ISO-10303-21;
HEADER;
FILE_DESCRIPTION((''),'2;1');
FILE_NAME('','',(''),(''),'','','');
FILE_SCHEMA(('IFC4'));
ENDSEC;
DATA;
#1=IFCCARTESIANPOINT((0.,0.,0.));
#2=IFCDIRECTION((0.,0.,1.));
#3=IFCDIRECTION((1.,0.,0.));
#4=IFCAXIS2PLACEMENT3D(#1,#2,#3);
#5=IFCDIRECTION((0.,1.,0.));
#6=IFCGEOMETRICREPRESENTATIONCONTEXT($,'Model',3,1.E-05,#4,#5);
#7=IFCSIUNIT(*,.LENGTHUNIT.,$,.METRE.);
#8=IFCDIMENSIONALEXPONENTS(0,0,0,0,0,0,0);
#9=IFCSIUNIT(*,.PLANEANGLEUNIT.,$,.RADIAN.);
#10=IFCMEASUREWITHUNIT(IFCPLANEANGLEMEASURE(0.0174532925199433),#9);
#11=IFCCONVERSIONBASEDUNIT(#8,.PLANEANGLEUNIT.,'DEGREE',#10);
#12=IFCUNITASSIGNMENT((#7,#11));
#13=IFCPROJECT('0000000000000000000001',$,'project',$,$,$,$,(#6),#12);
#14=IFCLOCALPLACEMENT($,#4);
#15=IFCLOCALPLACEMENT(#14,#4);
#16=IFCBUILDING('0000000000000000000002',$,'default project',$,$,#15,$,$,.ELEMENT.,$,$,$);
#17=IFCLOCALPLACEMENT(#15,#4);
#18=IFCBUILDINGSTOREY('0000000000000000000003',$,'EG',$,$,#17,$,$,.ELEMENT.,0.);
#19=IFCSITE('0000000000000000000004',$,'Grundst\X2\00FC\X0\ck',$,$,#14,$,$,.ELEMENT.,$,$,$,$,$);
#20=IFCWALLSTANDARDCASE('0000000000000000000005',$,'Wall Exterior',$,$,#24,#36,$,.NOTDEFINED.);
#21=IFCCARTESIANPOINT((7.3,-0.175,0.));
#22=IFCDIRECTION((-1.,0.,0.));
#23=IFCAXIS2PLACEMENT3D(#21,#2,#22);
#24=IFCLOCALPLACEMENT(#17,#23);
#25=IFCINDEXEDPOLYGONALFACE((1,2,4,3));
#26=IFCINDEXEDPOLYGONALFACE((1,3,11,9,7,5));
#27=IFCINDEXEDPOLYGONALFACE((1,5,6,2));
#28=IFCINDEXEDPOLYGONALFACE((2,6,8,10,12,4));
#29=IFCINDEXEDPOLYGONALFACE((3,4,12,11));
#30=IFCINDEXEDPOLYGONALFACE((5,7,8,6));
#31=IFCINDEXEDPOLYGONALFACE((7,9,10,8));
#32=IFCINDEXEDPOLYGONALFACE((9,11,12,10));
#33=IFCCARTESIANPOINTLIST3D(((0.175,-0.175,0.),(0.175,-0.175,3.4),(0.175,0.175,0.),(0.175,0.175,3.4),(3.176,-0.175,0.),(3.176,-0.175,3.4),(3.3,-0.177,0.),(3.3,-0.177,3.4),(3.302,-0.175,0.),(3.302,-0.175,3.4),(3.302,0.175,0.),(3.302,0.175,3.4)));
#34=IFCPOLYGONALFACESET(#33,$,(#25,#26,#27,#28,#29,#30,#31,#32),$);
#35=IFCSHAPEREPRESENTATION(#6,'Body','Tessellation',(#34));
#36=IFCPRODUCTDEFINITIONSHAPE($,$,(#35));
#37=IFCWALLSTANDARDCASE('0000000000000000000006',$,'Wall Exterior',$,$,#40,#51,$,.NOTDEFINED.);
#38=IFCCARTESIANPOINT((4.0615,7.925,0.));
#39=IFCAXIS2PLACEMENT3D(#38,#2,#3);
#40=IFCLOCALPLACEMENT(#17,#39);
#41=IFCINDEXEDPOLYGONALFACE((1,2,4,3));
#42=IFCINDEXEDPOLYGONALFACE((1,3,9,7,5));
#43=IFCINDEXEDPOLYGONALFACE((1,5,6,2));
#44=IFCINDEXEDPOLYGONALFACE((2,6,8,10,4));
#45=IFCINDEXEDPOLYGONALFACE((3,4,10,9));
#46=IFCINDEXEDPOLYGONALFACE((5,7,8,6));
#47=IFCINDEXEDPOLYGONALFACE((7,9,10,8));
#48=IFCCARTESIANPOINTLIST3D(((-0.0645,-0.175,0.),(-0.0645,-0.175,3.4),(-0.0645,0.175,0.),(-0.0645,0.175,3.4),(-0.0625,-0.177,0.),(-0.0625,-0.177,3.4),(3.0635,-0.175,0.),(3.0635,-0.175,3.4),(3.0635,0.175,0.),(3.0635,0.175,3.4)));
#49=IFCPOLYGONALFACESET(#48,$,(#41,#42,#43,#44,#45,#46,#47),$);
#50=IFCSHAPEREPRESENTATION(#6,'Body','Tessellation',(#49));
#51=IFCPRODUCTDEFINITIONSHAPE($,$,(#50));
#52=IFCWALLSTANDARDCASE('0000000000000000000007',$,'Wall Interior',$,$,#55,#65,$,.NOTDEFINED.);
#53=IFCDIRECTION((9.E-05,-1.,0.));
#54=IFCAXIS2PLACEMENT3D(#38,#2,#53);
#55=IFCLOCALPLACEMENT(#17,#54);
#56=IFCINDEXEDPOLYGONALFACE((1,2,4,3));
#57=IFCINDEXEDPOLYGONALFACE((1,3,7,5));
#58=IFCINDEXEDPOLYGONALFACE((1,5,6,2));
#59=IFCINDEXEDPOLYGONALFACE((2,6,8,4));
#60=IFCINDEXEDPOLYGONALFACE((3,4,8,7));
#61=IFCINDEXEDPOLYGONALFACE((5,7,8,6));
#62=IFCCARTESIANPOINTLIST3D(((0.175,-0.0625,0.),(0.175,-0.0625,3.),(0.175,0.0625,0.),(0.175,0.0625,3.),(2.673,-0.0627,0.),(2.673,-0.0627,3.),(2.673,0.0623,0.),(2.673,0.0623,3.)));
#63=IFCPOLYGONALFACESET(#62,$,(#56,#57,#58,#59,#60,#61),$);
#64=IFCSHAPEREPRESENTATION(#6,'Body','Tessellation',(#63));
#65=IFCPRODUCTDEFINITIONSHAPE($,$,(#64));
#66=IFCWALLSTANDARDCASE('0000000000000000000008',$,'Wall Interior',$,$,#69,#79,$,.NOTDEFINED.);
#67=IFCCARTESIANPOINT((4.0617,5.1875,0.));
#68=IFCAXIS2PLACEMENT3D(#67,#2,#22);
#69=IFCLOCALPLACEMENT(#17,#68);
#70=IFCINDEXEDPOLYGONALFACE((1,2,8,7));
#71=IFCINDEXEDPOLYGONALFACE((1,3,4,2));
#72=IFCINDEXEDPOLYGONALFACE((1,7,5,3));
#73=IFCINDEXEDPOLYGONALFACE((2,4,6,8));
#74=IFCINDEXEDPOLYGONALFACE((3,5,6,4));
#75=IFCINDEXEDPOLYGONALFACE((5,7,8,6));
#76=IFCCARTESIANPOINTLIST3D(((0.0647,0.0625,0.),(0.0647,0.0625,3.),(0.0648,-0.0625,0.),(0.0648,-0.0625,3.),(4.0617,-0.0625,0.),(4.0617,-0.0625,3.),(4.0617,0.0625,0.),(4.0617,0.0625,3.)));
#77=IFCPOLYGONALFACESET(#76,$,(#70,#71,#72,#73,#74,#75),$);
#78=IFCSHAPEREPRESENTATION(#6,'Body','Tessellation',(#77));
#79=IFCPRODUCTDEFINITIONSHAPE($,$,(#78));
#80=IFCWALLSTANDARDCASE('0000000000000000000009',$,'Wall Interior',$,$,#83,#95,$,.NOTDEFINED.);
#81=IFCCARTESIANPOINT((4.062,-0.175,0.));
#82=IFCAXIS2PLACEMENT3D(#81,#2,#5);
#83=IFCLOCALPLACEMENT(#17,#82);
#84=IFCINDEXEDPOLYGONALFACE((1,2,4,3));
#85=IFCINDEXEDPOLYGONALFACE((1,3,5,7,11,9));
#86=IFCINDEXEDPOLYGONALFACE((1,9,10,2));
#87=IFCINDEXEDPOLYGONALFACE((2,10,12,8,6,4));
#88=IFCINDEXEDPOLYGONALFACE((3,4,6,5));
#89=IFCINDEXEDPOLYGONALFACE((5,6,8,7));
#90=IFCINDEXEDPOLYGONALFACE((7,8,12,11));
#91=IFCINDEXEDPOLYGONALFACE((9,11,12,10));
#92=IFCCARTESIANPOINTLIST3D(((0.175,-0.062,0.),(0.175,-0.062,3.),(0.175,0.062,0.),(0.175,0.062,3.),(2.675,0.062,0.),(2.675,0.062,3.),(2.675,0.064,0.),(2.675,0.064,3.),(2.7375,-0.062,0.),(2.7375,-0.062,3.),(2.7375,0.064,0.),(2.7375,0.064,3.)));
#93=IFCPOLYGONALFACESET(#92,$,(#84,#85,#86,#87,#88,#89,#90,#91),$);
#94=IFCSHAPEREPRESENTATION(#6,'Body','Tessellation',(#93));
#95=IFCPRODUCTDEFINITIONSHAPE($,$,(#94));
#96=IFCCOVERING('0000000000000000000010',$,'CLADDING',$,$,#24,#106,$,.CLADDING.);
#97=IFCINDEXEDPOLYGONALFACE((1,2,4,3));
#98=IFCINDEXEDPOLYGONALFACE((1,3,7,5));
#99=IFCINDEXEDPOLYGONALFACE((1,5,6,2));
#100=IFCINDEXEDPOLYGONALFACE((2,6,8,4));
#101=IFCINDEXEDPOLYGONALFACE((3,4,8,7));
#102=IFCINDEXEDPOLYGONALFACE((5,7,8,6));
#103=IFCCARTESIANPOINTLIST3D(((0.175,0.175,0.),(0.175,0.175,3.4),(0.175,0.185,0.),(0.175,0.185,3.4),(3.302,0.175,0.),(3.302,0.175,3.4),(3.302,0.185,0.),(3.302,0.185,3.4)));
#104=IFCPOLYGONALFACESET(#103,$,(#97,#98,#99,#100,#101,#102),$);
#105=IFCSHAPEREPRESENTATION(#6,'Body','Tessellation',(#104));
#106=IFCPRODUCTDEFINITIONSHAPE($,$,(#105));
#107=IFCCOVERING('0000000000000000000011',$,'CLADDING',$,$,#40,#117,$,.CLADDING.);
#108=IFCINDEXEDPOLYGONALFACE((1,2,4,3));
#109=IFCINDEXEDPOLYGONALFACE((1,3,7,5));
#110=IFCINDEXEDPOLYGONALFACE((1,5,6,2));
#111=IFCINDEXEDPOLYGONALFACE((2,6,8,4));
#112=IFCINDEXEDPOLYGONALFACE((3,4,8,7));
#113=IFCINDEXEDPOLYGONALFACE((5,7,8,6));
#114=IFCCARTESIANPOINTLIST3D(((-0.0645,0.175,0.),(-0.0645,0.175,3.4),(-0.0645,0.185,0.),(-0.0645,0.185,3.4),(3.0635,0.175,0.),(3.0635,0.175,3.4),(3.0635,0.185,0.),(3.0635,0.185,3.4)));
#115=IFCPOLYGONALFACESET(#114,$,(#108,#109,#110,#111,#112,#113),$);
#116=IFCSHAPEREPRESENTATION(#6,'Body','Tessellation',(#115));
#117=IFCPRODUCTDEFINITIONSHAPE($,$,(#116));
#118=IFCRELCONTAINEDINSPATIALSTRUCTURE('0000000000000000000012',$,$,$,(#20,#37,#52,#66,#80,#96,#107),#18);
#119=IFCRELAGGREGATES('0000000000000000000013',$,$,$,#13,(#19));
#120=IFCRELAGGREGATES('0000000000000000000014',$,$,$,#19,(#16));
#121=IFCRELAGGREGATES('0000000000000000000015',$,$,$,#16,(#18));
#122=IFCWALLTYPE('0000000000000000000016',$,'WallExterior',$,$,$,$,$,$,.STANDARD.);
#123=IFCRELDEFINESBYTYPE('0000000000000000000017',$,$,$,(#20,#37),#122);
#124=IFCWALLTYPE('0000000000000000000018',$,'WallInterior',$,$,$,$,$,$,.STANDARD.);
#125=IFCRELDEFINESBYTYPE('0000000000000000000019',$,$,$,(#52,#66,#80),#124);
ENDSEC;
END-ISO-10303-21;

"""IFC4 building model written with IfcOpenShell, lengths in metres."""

from ifc_helpers import new_model, entity, si_unit, converted_unit, direction, frame, origin_with_axes, place, context, project, spatial, polyline, outline, extrude, type_object, element, save


model = new_model("IFC4")

# Units and contexts
model_context = context("Model", 3, precision=1e-05, world=origin_with_axes(), true_north=direction((0.0, 1.0, 0.0)))
ifc_project = project(units=[si_unit("LENGTHUNIT", "METRE"), converted_unit("PLANEANGLEUNIT", "DEGREE", entity("IfcPlaneAngleMeasure", 0.0174532925199433), si_unit("PLANEANGLEUNIT", "RADIAN"), dimensions=[0, 0, 0, 0, 0, 0, 0])], contexts=[model_context])

# Site, building, storey
site_placement = place(None, origin_with_axes())
site = spatial("IfcSite", under=ifc_project, at=site_placement, Name="Grundstück", CompositionType="ELEMENT")
building_placement = place(site_placement, origin_with_axes())
building = spatial("IfcBuilding", under=site, at=building_placement, Name="default project", CompositionType="ELEMENT")
placement_1 = place(building_placement, origin_with_axes())
storey = spatial("IfcBuildingStorey", under=building, at=placement_1, Name="EG", CompositionType="ELEMENT", Elevation=0.0)

# Walls
wall_type_1 = type_object("IfcWallType", Name="WallExterior", PredefinedType="STANDARD")
placement_2 = place(placement_1, frame((7.3, -0.175, 0.0), z_axis=(0.0, 0.0, 1.0), x_axis=(-1.0, 0.0, 0.0)))
element("IfcWallStandardCase", 1, at=placement_2, inside=storey, type_object=wall_type_1, Name="Wall Exterior", PredefinedType="NOTDEFINED", context=model_context, shape_type="SweptSolid", body=[
    extrude(outline(polyline([(3.302, -0.175), (3.302, 0.175), (0.175, 0.175), (0.175, -0.175), (3.176, -0.175), (3.3, -0.177), (3.302, -0.175)])), origin_with_axes(), (0.0, 0.0, 1.0), 3.4),
])
placement_3 = place(placement_1, frame((4.0615, 7.925, 0.0), z_axis=(0.0, 0.0, 1.0), x_axis=(1.0, 0.0, 0.0)))
element("IfcWallStandardCase", 2, at=placement_3, inside=storey, type_object=wall_type_1, Name="Wall Exterior", PredefinedType="NOTDEFINED", context=model_context, shape_type="SweptSolid", body=[
    extrude(outline(polyline([(-0.0645, 0.175), (-0.0645, -0.175), (-0.0625, -0.177), (3.0635, -0.175), (3.0635, 0.175), (-0.0645, 0.175)])), origin_with_axes(), (0.0, 0.0, 1.0), 3.4),
])
wall_type_2 = type_object("IfcWallType", Name="WallInterior", PredefinedType="STANDARD")
wall_1_placement = place(placement_1, frame((4.0615, 7.925, 0.0), z_axis=(0.0, 0.0, 1.0), x_axis=(0.00009, -1.0, 0.0)))
element("IfcWallStandardCase", 3, at=wall_1_placement, inside=storey, type_object=wall_type_2, Name="Wall Interior", PredefinedType="NOTDEFINED", context=model_context, shape_type="SweptSolid", body=[
    extrude(outline(polyline([(0.175, 0.0625), (0.175, -0.0625), (2.673, -0.0627), (2.673, 0.0623), (0.175, 0.0625)])), origin_with_axes(), (0.0, 0.0, 1.0), 3.0),
])
wall_2_placement = place(placement_1, frame((4.0617, 5.1875, 0.0), z_axis=(0.0, 0.0, 1.0), x_axis=(-1.0, 0.0, 0.0)))
element("IfcWallStandardCase", 4, at=wall_2_placement, inside=storey, type_object=wall_type_2, Name="Wall Interior", PredefinedType="NOTDEFINED", context=model_context, shape_type="SweptSolid", body=[
    extrude(outline(polyline([(0.0647, 0.0625), (0.0648, -0.0625), (4.0617, -0.0625), (4.0617, 0.0625), (0.0647, 0.0625)])), origin_with_axes(), (0.0, 0.0, 1.0), 3.0),
])
wall_3_placement = place(placement_1, frame((4.062, -0.175, 0.0), z_axis=(0.0, 0.0, 1.0), x_axis=(0.0, 1.0, 0.0)))
element("IfcWallStandardCase", 5, at=wall_3_placement, inside=storey, type_object=wall_type_2, Name="Wall Interior", PredefinedType="NOTDEFINED", context=model_context, shape_type="SweptSolid", body=[
    extrude(outline(polyline([(2.675, 0.064), (2.675, 0.062), (0.175, 0.062), (0.175, -0.062), (2.7375, -0.062), (2.7375, 0.064), (2.675, 0.064)])), origin_with_axes(), (0.0, 0.0, 1.0), 3.0),
])

# Coverings
element("IfcCovering", 6, at=placement_2, inside=storey, Name="CLADDING", PredefinedType="CLADDING", context=model_context, shape_type="SweptSolid", body=[
    extrude(outline(polyline([(3.302, 0.185), (0.175, 0.185), (0.175, 0.175), (3.302, 0.175), (3.302, 0.185)])), origin_with_axes(), (0.0, 0.0, 1.0), 3.4),
])
element("IfcCovering", 7, at=placement_3, inside=storey, Name="CLADDING", PredefinedType="CLADDING", context=model_context, shape_type="SweptSolid", body=[
    extrude(outline(polyline([(3.0635, 0.185), (-0.0645, 0.185), (-0.0645, 0.175), (3.0635, 0.175), (3.0635, 0.185)])), origin_with_axes(), (0.0, 0.0, 1.0), 3.4),
])

save(model, "model.ifc")
